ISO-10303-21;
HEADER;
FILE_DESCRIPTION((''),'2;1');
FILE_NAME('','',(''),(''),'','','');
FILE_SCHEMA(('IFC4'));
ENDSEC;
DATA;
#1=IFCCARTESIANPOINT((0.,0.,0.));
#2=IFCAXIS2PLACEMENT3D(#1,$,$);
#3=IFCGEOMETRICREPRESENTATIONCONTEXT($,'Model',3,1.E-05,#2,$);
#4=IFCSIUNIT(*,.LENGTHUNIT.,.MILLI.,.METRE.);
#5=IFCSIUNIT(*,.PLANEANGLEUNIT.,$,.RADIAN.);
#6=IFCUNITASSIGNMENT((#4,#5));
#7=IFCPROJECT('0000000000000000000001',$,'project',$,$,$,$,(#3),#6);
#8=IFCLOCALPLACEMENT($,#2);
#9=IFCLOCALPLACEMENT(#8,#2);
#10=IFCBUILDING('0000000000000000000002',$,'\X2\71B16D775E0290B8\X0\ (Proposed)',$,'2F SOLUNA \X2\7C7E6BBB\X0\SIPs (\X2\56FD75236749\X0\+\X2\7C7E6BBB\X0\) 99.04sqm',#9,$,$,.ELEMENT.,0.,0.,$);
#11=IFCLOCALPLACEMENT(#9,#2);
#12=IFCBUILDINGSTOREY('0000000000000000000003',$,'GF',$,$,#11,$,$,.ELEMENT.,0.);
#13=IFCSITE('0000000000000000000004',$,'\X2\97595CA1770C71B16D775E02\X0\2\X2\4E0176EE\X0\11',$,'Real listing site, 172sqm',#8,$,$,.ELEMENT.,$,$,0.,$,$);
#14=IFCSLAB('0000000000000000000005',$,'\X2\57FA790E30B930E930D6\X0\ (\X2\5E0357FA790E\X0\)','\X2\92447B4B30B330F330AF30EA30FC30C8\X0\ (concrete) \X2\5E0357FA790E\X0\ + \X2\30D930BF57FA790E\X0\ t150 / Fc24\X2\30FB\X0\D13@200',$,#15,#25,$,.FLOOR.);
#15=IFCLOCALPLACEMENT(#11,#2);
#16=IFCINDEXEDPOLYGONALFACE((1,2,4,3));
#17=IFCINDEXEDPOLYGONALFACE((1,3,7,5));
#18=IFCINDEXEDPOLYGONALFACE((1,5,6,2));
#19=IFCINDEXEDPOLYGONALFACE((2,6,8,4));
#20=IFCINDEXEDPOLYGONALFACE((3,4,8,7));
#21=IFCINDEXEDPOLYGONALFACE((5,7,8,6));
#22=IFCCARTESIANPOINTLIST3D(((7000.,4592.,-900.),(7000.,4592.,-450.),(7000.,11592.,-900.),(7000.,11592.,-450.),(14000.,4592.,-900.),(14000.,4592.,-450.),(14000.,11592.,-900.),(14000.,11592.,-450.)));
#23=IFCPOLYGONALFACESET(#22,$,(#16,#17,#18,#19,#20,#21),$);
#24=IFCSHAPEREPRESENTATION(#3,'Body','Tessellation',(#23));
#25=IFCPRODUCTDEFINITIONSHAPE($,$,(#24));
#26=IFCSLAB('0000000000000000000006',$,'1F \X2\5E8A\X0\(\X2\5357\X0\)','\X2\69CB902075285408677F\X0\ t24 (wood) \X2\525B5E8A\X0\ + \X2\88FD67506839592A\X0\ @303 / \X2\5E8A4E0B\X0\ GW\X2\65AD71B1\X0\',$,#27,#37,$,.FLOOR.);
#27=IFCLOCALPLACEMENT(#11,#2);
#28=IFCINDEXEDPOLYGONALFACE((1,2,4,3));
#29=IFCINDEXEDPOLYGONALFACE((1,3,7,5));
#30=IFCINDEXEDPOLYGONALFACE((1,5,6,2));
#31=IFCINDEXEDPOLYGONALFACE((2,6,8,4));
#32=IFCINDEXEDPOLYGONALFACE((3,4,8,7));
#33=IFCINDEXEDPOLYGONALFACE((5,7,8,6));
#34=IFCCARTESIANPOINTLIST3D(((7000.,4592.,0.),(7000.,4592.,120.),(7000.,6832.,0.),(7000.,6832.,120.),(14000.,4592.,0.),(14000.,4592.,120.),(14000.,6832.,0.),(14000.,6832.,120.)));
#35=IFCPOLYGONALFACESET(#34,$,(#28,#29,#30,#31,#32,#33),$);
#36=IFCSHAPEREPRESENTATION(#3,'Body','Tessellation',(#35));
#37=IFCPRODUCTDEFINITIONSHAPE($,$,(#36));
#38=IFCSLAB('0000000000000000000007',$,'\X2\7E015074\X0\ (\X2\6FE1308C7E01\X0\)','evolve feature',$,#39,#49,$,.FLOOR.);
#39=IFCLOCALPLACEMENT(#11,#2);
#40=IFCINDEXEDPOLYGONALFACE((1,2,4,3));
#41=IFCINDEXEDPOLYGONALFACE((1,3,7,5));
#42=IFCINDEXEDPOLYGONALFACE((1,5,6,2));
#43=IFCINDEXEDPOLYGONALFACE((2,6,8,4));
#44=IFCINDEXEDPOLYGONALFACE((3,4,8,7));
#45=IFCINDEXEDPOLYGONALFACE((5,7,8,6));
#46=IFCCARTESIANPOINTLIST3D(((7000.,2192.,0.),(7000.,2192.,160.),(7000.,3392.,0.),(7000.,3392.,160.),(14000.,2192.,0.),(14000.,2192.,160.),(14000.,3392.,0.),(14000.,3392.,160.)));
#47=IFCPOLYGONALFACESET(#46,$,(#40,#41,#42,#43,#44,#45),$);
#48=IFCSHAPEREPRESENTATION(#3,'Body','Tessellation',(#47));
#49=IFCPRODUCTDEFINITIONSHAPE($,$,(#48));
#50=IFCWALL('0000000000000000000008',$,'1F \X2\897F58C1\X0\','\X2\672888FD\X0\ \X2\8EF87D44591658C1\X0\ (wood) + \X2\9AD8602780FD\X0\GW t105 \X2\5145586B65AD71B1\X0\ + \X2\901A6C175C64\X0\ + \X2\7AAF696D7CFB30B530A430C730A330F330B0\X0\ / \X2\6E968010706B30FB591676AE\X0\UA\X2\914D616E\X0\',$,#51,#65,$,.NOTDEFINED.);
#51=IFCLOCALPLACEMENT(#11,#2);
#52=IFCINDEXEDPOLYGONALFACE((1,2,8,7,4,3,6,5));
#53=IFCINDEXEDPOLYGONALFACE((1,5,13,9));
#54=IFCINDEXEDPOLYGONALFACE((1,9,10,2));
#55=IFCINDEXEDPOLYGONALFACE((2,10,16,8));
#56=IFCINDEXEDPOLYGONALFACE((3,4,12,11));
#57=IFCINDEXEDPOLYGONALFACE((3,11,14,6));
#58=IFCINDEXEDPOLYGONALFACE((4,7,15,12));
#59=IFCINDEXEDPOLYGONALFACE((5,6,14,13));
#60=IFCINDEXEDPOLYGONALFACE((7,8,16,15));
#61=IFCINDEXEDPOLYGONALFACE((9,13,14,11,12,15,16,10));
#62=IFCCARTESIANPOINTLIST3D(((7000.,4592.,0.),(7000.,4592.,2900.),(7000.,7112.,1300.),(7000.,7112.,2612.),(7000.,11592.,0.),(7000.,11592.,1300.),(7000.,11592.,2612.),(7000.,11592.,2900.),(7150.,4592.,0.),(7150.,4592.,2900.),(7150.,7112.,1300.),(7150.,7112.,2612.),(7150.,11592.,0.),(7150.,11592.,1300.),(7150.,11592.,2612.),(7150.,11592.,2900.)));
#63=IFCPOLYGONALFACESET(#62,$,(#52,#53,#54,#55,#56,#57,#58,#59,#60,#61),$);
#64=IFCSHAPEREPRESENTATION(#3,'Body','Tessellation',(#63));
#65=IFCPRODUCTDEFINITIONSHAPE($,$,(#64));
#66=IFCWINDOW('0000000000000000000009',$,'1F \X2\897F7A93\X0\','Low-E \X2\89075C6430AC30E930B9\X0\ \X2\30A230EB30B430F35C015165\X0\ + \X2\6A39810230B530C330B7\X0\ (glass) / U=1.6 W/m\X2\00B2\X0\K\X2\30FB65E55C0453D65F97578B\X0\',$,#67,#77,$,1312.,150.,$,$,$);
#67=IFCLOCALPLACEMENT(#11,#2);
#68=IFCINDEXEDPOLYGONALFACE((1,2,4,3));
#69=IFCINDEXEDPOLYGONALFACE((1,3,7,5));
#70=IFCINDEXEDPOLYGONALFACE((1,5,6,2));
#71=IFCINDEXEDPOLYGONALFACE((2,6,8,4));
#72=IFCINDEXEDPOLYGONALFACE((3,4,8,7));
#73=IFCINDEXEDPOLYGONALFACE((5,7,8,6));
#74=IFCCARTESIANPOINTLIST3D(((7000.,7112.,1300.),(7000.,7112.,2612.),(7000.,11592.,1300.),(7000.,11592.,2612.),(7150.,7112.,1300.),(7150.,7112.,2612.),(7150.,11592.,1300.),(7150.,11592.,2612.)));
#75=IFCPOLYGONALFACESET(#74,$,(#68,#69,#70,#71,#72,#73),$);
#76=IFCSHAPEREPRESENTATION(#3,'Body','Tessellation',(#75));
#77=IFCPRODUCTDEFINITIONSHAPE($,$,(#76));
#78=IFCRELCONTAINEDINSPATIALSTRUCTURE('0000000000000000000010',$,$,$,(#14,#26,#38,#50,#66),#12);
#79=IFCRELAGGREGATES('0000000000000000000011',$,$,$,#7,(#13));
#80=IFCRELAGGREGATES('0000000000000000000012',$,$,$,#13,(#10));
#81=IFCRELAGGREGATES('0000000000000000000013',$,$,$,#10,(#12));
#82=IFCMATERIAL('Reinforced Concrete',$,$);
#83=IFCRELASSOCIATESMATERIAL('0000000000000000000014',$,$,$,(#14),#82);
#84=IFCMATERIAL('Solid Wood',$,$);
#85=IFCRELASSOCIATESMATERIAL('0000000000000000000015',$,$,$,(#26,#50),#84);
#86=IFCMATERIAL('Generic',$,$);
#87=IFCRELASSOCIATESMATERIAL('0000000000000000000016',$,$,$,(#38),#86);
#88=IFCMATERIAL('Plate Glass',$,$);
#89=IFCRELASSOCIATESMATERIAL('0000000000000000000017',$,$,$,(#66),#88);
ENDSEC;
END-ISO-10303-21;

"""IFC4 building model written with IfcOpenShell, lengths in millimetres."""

from ifc_helpers import new_model, si_unit, frame, frame_2d, origin, place, context, project, spatial, rectangle, extrude, material, element, fill, save


model = new_model("IFC4")

# Units and contexts
model_context = context("Model", 3, precision=1e-05, world=origin())
ifc_project = project(units=[si_unit("LENGTHUNIT", "METRE", prefix="MILLI"), si_unit("PLANEANGLEUNIT", "RADIAN")], contexts=[model_context])

# Site, building, storey
site_placement = place(None, origin())
site = spatial("IfcSite", under=ifc_project, at=site_placement, Name="静岡県熱海市2丁目11", ObjectType="Real listing site, 172sqm", CompositionType="ELEMENT", RefElevation=0.0)
building_placement = place(site_placement, origin())
building = spatial("IfcBuilding", under=site, at=building_placement, Name="熱海市邸 (Proposed)", ObjectType="2F SOLUNA 籾殻SIPs (国産杉+籾殻) 99.04sqm", CompositionType="ELEMENT", ElevationOfRefHeight=0.0, ElevationOfTerrain=0.0)
storey_placement = place(building_placement, origin())
storey = spatial("IfcBuildingStorey", under=building, at=storey_placement, Name="GF", CompositionType="ELEMENT", Elevation=0.0)

# Slabs
ifc_material_1 = material(Name="Reinforced Concrete")
slab_1_placement = place(storey_placement, frame((3500.0, 2296.0, -450.0)))
element("IfcSlab", 1, at=slab_1_placement, inside=storey, material=ifc_material_1, Name="基礎スラブ (布基礎)", Description="鉄筋コンクリート (concrete) 布基礎 + ベタ基礎 t150 / Fc24・D13@200", PredefinedType="FLOOR", context=model_context, shape_type="SweptSolid", body=[
    extrude(rectangle(XDim=7000.0, YDim=7000.0, at=frame_2d((3500.0, 3500.0))), frame((3500.0, 2296.0, -450.0)), (0.0, 0.0, 1.0), 450.0),
])
ifc_material_2 = material(Name="Solid Wood")
slab_2_placement = place(storey_placement, frame((3500.0, 2296.0, 0.0)))
element("IfcSlab", 2, at=slab_2_placement, inside=storey, material=ifc_material_2, Name="1F 床(南)", Description="構造用合板 t24 (wood) 剛床 + 製材根太 @303 / 床下 GW断熱", PredefinedType="FLOOR", context=model_context, shape_type="SweptSolid", body=[
    extrude(rectangle(XDim=7000.0, YDim=2240.0, at=frame_2d((3500.0, 1120.0))), frame((3500.0, 2296.0, 0.0)), (0.0, 0.0, 1.0), 120.0),
])
ifc_material_3 = material(Name="Generic")
slab_3_placement = place(storey_placement, frame((3500.0, 1096.0, 0.0)))
element("IfcSlab", 3, at=slab_3_placement, inside=storey, material=ifc_material_3, Name="縁側 (濡れ縁)", Description="evolve feature", PredefinedType="FLOOR", context=model_context, shape_type="SweptSolid", body=[
    extrude(rectangle(XDim=7000.0, YDim=1200.0, at=frame_2d((3500.0, 600.0))), frame((3500.0, 1096.0, 0.0)), (0.0, 0.0, 1.0), 160.0),
])

# Shared definitions
ifc_material_4 = material(Name="Plate Glass")

# Wall, opening, window
wall_1_placement = place(storey_placement, frame((3500.0, 2296.0, 0.0)))
wall_1 = element("IfcWall", 4, at=wall_1_placement, inside=storey, material=ifc_material_2, Name="1F 西壁", Description="木製 軸組外壁 (wood) + 高性能GW t105 充填断熱 + 通気層 + 窯業系サイディング / 準耐火・外皮UA配慮", PredefinedType="NOTDEFINED", context=model_context, shape_type="SweptSolid", body=[
    extrude(rectangle(XDim=150.0, YDim=7000.0, at=frame_2d((75.0, 3500.0))), frame((3500.0, 2296.0, 0.0)), (0.0, 0.0, 1.0), 2900.0),
])
opening_1_placement = place(storey_placement, frame((3500.0, 3556.0, 650.0)))
opening_1 = element("IfcOpeningElement", 5, at=opening_1_placement, cuts=wall_1, PredefinedType="NOTDEFINED", context=model_context, shape_type="SweptSolid", body=[
    extrude(rectangle(XDim=150.0, YDim=4480.0, at=frame_2d((75.0, 2240.0))), frame((3500.0, 3556.0, 650.0)), (0.0, 0.0, 1.0), 1312.0),
])
window_1_placement = place(storey_placement, frame((3500.0, 3556.0, 650.0)))
window_1 = element("IfcWindow", 6, at=window_1_placement, inside=storey, material=ifc_material_4, Name="1F 西窓", Description="Low-E 複層ガラス アルゴン封入 + 樹脂サッシ (glass) / U=1.6 W/m²K・日射取得型", OverallHeight=1312.0, OverallWidth=150.0, context=model_context, shape_type="SweptSolid", body=[
    extrude(rectangle(XDim=150.0, YDim=4480.0, at=frame_2d((75.0, 2240.0))), frame((3500.0, 3556.0, 650.0)), (0.0, 0.0, 1.0), 1312.0),
])
fill(opening_1, window_1)

save(model, "model.ifc")
